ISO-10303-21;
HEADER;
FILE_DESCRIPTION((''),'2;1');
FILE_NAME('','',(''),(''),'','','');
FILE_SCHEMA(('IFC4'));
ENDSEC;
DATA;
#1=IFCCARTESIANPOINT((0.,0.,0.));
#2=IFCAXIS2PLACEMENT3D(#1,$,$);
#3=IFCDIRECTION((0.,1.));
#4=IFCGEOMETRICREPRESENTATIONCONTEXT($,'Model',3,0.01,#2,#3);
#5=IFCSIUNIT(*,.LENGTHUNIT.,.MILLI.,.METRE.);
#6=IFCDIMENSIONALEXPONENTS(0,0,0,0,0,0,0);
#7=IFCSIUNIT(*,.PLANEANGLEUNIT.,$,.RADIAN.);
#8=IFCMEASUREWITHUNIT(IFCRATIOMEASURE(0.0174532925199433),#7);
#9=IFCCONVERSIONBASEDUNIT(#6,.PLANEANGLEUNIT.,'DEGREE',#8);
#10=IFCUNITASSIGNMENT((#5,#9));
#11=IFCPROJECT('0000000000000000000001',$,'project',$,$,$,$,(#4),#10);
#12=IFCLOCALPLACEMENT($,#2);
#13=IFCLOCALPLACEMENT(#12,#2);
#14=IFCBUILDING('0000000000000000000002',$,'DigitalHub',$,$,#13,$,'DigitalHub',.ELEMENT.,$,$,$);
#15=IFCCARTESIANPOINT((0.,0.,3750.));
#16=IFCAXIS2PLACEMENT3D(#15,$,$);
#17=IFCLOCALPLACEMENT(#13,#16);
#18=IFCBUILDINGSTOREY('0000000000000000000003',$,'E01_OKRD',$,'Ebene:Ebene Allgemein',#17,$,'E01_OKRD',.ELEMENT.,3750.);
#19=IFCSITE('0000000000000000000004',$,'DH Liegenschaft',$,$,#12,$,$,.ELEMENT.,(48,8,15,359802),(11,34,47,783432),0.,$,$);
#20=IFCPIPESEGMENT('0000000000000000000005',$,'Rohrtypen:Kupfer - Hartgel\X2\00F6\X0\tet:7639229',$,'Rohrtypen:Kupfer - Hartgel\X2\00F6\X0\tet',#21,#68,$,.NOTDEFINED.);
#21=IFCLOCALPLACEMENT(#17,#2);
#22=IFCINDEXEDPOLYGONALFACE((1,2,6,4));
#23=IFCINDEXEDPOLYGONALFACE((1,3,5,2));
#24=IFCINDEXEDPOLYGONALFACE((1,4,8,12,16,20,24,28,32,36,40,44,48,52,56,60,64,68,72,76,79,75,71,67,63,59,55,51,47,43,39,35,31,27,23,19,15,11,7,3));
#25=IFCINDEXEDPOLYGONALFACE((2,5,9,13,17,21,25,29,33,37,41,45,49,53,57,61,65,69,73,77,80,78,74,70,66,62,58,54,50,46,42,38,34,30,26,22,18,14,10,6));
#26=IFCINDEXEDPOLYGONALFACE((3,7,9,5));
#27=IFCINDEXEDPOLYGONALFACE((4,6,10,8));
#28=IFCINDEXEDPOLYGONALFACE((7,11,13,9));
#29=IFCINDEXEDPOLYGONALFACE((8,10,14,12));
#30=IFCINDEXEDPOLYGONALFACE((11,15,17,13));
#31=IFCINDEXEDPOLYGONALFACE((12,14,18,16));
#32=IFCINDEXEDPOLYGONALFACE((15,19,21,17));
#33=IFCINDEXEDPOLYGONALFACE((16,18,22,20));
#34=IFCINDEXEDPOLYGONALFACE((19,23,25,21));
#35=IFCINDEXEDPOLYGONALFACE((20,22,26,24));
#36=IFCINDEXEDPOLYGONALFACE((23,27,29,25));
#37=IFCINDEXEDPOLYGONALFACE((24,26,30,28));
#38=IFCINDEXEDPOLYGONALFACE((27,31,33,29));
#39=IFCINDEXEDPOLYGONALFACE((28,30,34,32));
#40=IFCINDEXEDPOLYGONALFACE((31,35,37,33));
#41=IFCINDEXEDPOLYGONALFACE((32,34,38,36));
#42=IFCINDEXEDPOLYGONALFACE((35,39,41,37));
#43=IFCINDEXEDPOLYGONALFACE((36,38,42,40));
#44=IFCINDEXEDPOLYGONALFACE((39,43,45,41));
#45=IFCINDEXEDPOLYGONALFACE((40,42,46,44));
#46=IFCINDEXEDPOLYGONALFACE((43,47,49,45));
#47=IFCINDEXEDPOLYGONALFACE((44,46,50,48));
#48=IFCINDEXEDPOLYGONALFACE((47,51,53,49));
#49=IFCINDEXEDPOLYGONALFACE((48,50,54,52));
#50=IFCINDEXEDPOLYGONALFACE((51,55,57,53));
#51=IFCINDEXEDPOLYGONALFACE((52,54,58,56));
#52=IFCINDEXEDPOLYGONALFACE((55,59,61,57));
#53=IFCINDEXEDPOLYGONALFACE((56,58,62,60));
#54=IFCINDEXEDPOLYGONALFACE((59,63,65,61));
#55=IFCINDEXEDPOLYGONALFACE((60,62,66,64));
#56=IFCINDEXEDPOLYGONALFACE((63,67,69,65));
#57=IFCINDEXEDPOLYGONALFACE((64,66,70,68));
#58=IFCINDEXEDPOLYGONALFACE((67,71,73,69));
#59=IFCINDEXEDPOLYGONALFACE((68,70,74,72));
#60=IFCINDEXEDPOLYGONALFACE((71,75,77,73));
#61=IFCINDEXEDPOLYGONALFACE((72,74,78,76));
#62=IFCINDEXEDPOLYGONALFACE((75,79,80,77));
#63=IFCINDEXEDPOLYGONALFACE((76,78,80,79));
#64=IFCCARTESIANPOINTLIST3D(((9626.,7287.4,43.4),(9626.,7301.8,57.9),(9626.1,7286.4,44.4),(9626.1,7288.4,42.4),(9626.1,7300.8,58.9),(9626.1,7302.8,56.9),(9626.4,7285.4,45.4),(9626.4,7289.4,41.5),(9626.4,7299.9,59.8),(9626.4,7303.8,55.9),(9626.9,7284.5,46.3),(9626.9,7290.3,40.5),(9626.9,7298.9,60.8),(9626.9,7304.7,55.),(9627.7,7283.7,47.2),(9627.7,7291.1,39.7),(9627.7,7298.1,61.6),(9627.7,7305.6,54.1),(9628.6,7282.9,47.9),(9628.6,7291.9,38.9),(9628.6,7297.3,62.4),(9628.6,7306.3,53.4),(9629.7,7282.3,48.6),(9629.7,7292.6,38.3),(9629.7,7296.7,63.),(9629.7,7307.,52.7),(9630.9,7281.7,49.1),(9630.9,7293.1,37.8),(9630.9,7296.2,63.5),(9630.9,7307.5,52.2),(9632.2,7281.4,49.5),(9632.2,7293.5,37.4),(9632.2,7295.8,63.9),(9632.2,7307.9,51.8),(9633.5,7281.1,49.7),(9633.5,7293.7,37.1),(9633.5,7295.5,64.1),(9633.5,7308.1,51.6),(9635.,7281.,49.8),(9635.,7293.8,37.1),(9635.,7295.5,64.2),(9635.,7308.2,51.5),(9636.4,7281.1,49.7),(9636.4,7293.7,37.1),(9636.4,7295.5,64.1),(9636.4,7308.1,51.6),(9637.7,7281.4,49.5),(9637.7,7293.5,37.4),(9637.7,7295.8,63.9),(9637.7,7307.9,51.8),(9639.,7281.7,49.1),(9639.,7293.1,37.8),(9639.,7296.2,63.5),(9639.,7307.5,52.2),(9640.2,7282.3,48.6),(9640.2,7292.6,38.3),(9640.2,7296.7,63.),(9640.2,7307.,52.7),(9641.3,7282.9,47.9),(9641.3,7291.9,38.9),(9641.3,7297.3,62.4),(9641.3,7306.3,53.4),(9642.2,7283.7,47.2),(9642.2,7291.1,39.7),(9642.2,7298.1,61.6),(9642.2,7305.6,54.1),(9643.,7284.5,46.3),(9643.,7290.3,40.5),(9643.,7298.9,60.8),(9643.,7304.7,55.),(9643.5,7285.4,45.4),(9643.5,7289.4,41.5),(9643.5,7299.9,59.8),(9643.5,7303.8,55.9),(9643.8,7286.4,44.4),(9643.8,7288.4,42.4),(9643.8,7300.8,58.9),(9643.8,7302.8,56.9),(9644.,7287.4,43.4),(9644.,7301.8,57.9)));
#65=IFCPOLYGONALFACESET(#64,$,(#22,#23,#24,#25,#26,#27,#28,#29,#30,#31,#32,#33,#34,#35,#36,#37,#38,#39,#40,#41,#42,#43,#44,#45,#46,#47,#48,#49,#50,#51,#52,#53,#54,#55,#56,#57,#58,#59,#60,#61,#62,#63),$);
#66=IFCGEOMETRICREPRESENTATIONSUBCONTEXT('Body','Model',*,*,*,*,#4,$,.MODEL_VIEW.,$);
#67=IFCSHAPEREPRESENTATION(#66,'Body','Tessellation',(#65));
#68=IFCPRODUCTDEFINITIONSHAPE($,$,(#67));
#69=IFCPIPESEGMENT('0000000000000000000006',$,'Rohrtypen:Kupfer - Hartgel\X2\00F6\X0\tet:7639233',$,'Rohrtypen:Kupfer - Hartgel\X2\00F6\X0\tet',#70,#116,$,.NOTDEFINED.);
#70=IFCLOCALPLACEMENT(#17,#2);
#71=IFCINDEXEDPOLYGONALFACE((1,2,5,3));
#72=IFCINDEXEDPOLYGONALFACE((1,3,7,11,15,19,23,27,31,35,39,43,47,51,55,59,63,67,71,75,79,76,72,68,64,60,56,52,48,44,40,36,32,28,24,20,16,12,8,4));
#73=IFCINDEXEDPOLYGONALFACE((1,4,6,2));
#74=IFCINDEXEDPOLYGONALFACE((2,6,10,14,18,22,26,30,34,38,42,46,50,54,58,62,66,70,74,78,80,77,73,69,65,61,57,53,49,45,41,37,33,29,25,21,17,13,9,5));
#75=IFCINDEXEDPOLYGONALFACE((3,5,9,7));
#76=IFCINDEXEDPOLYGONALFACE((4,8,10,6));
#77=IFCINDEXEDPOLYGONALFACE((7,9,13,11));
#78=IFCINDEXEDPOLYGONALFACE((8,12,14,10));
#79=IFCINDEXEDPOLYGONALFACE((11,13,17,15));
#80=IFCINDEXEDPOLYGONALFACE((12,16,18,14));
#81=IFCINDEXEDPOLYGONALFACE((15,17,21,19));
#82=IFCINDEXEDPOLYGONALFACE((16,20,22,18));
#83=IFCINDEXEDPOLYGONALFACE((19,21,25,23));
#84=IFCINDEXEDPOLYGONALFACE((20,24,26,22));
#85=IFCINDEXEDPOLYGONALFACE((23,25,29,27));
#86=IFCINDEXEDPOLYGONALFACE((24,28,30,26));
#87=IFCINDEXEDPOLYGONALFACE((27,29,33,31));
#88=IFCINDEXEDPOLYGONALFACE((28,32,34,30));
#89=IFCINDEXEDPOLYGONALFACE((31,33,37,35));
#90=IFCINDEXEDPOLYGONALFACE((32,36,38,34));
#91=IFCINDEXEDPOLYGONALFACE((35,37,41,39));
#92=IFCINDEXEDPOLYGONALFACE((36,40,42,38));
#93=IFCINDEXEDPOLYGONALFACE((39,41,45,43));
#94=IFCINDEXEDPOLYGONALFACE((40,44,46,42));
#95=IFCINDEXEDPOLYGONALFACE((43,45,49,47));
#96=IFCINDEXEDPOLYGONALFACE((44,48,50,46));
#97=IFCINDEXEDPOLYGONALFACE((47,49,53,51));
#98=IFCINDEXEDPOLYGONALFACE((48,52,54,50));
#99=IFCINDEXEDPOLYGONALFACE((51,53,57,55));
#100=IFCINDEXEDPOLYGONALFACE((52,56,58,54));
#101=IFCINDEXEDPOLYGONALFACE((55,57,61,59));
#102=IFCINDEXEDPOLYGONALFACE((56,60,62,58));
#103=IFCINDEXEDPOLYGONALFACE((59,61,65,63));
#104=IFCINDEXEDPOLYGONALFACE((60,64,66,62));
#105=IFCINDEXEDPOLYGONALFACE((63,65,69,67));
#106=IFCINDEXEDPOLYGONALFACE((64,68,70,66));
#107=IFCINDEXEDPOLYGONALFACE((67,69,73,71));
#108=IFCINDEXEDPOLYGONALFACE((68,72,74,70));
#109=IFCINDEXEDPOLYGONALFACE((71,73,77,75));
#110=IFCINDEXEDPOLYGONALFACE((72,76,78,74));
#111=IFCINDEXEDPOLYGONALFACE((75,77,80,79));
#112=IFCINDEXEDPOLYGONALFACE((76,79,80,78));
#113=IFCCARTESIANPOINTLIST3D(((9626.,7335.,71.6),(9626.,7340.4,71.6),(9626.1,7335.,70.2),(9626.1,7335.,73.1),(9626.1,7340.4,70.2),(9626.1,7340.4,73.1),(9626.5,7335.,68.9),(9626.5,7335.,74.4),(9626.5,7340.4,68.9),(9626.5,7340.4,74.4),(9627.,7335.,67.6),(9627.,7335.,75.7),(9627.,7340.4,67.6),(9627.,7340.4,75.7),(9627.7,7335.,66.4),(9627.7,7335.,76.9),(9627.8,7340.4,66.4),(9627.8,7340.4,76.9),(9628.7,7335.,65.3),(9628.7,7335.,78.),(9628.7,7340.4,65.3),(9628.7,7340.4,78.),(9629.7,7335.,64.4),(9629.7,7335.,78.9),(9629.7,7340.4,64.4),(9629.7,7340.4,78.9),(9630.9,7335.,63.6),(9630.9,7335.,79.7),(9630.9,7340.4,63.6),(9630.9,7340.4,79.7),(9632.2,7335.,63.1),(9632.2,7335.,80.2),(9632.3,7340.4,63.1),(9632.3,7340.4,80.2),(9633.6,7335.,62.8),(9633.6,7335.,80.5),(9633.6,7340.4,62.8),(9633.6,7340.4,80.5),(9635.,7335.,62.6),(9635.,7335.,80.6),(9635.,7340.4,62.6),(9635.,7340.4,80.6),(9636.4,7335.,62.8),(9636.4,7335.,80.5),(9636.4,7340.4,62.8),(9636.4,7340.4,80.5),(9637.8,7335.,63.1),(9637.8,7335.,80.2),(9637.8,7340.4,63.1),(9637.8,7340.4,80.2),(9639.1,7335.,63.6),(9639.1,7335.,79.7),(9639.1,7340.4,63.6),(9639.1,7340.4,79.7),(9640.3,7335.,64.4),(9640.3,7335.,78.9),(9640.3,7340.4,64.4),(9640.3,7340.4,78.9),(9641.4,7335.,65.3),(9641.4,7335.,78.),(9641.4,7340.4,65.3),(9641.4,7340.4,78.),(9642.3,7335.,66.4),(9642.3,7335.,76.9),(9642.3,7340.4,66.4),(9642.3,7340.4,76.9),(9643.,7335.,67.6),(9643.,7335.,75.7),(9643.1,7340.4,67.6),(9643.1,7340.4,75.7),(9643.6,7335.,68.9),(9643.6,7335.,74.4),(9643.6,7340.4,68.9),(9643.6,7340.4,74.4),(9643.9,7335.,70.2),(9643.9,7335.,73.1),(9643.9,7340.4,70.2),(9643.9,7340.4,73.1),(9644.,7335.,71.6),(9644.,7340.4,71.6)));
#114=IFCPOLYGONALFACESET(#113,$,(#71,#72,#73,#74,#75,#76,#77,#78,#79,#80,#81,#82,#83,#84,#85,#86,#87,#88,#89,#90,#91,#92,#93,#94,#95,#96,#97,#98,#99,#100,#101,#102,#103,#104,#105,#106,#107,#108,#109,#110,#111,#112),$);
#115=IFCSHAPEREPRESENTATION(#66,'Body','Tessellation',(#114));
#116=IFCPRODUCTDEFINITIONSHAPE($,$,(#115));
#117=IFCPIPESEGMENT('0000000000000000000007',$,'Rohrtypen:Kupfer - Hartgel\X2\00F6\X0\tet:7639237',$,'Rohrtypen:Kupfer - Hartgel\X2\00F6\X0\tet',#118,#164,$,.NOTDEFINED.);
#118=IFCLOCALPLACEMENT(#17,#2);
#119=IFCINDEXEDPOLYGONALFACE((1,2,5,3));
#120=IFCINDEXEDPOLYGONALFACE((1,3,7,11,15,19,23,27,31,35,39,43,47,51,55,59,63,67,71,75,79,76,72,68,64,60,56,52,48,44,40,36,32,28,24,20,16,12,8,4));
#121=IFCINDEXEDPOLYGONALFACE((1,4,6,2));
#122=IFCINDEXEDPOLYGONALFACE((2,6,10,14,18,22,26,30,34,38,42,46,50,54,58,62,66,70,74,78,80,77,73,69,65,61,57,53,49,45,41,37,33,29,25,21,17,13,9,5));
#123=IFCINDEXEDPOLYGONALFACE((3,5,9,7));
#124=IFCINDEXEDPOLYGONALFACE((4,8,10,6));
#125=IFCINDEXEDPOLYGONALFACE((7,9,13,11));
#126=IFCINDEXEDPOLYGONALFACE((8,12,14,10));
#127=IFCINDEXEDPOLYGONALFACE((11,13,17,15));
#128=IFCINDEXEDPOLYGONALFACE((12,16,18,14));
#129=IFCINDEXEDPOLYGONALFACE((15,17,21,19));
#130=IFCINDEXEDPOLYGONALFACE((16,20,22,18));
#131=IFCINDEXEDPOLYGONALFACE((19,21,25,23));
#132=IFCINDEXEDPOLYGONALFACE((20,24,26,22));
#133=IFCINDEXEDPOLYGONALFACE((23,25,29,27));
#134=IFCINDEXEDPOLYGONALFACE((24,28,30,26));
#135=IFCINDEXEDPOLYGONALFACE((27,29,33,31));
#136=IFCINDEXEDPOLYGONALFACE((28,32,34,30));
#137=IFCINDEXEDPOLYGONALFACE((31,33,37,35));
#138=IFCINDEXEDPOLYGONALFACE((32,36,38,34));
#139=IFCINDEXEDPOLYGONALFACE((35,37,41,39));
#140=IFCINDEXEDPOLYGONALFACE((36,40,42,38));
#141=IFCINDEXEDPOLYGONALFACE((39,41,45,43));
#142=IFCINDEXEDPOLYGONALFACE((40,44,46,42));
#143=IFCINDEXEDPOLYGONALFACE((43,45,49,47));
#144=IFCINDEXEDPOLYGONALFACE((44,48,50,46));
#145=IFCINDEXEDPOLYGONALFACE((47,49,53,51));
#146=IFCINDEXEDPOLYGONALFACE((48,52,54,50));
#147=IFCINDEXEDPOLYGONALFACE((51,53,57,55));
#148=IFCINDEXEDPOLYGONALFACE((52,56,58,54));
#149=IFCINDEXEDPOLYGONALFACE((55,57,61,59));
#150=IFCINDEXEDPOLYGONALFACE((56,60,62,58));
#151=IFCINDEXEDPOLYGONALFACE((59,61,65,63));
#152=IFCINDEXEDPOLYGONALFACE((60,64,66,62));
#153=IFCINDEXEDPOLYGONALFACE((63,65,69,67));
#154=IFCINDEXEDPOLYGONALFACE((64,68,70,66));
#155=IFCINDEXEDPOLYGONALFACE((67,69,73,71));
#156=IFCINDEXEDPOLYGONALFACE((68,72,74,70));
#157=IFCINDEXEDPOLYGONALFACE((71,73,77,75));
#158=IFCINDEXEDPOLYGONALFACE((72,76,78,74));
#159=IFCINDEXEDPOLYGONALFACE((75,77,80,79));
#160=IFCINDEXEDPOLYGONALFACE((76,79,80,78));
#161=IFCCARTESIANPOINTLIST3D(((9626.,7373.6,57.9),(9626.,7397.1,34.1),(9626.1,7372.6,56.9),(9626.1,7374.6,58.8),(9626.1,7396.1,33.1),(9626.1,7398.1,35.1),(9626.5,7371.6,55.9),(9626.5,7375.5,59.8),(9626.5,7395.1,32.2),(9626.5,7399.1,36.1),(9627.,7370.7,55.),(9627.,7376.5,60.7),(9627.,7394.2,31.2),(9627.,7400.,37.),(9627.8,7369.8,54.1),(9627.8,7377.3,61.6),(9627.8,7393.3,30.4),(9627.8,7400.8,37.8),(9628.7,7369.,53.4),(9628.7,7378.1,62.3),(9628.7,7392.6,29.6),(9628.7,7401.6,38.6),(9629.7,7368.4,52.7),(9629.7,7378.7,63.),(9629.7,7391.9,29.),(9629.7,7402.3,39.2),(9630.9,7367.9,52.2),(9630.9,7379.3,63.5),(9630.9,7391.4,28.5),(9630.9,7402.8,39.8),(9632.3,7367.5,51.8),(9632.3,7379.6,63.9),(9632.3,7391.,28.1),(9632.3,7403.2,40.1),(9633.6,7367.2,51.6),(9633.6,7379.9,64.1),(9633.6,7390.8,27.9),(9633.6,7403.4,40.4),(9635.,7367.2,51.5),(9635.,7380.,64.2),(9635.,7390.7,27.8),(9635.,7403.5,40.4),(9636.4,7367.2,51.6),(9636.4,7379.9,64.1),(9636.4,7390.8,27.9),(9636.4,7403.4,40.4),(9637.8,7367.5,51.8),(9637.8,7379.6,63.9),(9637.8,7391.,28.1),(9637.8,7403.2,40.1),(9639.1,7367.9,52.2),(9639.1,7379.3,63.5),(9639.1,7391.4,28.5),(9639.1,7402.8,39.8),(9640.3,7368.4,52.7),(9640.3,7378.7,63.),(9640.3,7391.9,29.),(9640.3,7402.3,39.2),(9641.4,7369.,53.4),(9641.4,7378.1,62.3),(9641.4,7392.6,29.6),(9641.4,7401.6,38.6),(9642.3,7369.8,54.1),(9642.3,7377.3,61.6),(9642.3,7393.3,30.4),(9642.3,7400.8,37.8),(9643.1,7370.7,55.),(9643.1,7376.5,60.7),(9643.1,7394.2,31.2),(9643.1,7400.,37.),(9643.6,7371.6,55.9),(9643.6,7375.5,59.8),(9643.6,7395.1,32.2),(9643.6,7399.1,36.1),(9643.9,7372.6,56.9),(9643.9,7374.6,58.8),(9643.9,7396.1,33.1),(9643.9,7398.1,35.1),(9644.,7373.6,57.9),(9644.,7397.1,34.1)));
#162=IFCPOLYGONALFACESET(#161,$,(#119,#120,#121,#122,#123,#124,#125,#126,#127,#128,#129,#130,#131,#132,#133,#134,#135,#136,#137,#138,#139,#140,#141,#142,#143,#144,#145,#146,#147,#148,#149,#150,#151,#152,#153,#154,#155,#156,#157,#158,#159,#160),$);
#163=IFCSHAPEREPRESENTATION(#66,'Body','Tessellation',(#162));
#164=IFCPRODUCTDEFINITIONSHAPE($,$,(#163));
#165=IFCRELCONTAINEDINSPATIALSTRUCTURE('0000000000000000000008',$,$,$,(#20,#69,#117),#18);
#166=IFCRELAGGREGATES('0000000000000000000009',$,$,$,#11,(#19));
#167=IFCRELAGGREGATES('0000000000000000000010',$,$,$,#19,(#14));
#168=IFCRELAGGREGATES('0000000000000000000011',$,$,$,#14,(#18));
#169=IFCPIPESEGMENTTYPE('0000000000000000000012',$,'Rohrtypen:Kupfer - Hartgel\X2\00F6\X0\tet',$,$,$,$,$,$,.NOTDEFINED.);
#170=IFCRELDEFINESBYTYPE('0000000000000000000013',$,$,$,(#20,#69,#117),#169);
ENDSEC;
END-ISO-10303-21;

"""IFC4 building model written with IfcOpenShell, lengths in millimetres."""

from ifc_helpers import new_model, entity, si_unit, converted_unit, direction, frame, origin, place, context, subcontext, project, spatial, indexed_curve, outline, extrude, type_object, element, save


model = new_model("IFC4")

# Units and contexts
model_context = context("Model", 3, precision=0.01, world=origin(), true_north=direction((0.0, 1.0)))
body_context = subcontext(model_context, "Body", "Model", "MODEL_VIEW")
ifc_project = project(units=[si_unit("LENGTHUNIT", "METRE", prefix="MILLI"), converted_unit("PLANEANGLEUNIT", "DEGREE", entity("IfcRatioMeasure", 0.0174532925199433), si_unit("PLANEANGLEUNIT", "RADIAN"), dimensions=[0, 0, 0, 0, 0, 0, 0])], contexts=[model_context])

# Site, building, storey
site_placement = place(None, origin())
site = spatial("IfcSite", under=ifc_project, at=site_placement, Name="DH Liegenschaft", CompositionType="ELEMENT", RefLatitude=(48, 8, 15, 359802), RefLongitude=(11, 34, 47, 783432), RefElevation=0.0)
building_placement = place(site_placement, origin())
building = spatial("IfcBuilding", under=site, at=building_placement, Name="DigitalHub", LongName="DigitalHub", CompositionType="ELEMENT")
storey_placement = place(building_placement, frame((0.0, 0.0, 3750.0)))
storey = spatial("IfcBuildingStorey", under=building, at=storey_placement, Name="E01_OKRD", ObjectType="Ebene:Ebene Allgemein", LongName="E01_OKRD", CompositionType="ELEMENT", Elevation=3750.0)

# Pipe segments
pipe_segment_type = type_object("IfcPipeSegmentType", Name="Rohrtypen:Kupfer - Hartgelötet", PredefinedType="NOTDEFINED")
pipe_segment_1_placement = place(storey_placement, frame((9624.4, 7279.4, 35.5)))
element("IfcPipeSegment", 1, at=pipe_segment_1_placement, inside=storey, type_object=pipe_segment_type, Name="Rohrtypen:Kupfer - Hartgelötet:7639229", ObjectType="Rohrtypen:Kupfer - Hartgelötet", PredefinedType="NOTDEFINED", context=body_context, shape_type="SweptSolid", body=[
    extrude(outline(indexed_curve([(9.0, 0.0), (8.9, 1.4), (8.6, 2.8), (8.0, 4.1), (7.3, 5.3), (6.4, 6.4), (5.3, 7.3), (4.1, 8.0), (2.8, 8.6), (1.4, 8.9), (0.0, 9.0), (-1.4, 8.9), (-2.8, 8.6), (-4.1, 8.0), (-5.3, 7.3), (-6.4, 6.4), (-7.3, 5.3), (-8.0, 4.1), (-8.6, 2.8), (-8.9, 1.4), (-9.0, 0.0), (-8.9, -1.4), (-8.6, -2.8), (-8.0, -4.1), (-7.3, -5.3), (-6.4, -6.4), (-5.3, -7.3), (-4.1, -8.0), (-2.8, -8.6), (-1.4, -8.9), (0.0, -9.0), (1.4, -8.9), (2.8, -8.6), (4.1, -8.0), (5.3, -7.3), (6.4, -6.4), (7.3, -5.3), (8.0, -4.1), (8.6, -2.8), (8.9, -1.4), (9.0, 0.0)], self_intersect=False)), frame((10.6, 8.0, 8.0), z_axis=(0.0, 0.707107, 0.707107), x_axis=(1.0, 0.0, 0.0)), (0.0, 0.0, 1.0), 20.4),
])
pipe_segment_2_placement = place(storey_placement, frame((9624.4, 7335.0, 61.1)))
element("IfcPipeSegment", 2, at=pipe_segment_2_placement, inside=storey, type_object=pipe_segment_type, Name="Rohrtypen:Kupfer - Hartgelötet:7639233", ObjectType="Rohrtypen:Kupfer - Hartgelötet", PredefinedType="NOTDEFINED", context=body_context, shape_type="SweptSolid", body=[
    extrude(outline(indexed_curve([(9.0, 0.0), (8.9, 1.4), (8.6, 2.8), (8.0, 4.1), (7.3, 5.3), (6.4, 6.4), (5.3, 7.3), (4.1, 8.0), (2.8, 8.6), (1.4, 8.9), (0.0, 9.0), (-1.4, 8.9), (-2.8, 8.6), (-4.1, 8.0), (-5.3, 7.3), (-6.4, 6.4), (-7.3, 5.3), (-8.0, 4.1), (-8.6, 2.8), (-8.9, 1.4), (-9.0, 0.0), (-8.9, -1.4), (-8.6, -2.8), (-8.0, -4.1), (-7.3, -5.3), (-6.4, -6.4), (-5.3, -7.3), (-4.1, -8.0), (-2.8, -8.6), (-1.4, -8.9), (0.0, -9.0), (1.4, -8.9), (2.8, -8.6), (4.1, -8.0), (5.3, -7.3), (6.4, -6.4), (7.3, -5.3), (8.0, -4.1), (8.6, -2.8), (8.9, -1.4), (9.0, 0.0)], self_intersect=False)), frame((10.6, 0.0, 10.6), z_axis=(0.003269, 0.999995, 0.0), x_axis=(-0.999995, 0.003269, -0.000001)), (0.0, 0.0, 1.0), 5.4),
])
pipe_segment_3_placement = place(storey_placement, frame((9624.4, 7365.6, 26.2)))
element("IfcPipeSegment", 3, at=pipe_segment_3_placement, inside=storey, type_object=pipe_segment_type, Name="Rohrtypen:Kupfer - Hartgelötet:7639237", ObjectType="Rohrtypen:Kupfer - Hartgelötet", PredefinedType="NOTDEFINED", context=body_context, shape_type="SweptSolid", body=[
    extrude(outline(indexed_curve([(9.0, 0.0), (8.9, 1.4), (8.6, 2.8), (8.0, 4.1), (7.3, 5.3), (6.4, 6.4), (5.3, 7.3), (4.1, 8.0), (2.8, 8.6), (1.4, 8.9), (0.0, 9.0), (-1.4, 8.9), (-2.8, 8.6), (-4.1, 8.0), (-5.3, 7.3), (-6.4, 6.4), (-7.3, 5.3), (-8.0, 4.1), (-8.6, 2.8), (-8.9, 1.4), (-9.0, 0.0), (-8.9, -1.4), (-8.6, -2.8), (-8.0, -4.1), (-7.3, -5.3), (-6.4, -6.4), (-5.3, -7.3), (-4.1, -8.0), (-2.8, -8.6), (-1.4, -8.9), (0.0, -9.0), (1.4, -8.9), (2.8, -8.6), (4.1, -8.0), (5.3, -7.3), (6.4, -6.4), (7.3, -5.3), (8.0, -4.1), (8.6, -2.8), (8.9, -1.4), (9.0, 0.0)], self_intersect=False)), frame((10.6, 31.5, 7.9), z_axis=(0.0, -0.70394, 0.71026), x_axis=(-1.0, 0.0, 0.0)), (0.0, 0.0, 1.0), 33.4),
])

save(model, "model.ifc")
